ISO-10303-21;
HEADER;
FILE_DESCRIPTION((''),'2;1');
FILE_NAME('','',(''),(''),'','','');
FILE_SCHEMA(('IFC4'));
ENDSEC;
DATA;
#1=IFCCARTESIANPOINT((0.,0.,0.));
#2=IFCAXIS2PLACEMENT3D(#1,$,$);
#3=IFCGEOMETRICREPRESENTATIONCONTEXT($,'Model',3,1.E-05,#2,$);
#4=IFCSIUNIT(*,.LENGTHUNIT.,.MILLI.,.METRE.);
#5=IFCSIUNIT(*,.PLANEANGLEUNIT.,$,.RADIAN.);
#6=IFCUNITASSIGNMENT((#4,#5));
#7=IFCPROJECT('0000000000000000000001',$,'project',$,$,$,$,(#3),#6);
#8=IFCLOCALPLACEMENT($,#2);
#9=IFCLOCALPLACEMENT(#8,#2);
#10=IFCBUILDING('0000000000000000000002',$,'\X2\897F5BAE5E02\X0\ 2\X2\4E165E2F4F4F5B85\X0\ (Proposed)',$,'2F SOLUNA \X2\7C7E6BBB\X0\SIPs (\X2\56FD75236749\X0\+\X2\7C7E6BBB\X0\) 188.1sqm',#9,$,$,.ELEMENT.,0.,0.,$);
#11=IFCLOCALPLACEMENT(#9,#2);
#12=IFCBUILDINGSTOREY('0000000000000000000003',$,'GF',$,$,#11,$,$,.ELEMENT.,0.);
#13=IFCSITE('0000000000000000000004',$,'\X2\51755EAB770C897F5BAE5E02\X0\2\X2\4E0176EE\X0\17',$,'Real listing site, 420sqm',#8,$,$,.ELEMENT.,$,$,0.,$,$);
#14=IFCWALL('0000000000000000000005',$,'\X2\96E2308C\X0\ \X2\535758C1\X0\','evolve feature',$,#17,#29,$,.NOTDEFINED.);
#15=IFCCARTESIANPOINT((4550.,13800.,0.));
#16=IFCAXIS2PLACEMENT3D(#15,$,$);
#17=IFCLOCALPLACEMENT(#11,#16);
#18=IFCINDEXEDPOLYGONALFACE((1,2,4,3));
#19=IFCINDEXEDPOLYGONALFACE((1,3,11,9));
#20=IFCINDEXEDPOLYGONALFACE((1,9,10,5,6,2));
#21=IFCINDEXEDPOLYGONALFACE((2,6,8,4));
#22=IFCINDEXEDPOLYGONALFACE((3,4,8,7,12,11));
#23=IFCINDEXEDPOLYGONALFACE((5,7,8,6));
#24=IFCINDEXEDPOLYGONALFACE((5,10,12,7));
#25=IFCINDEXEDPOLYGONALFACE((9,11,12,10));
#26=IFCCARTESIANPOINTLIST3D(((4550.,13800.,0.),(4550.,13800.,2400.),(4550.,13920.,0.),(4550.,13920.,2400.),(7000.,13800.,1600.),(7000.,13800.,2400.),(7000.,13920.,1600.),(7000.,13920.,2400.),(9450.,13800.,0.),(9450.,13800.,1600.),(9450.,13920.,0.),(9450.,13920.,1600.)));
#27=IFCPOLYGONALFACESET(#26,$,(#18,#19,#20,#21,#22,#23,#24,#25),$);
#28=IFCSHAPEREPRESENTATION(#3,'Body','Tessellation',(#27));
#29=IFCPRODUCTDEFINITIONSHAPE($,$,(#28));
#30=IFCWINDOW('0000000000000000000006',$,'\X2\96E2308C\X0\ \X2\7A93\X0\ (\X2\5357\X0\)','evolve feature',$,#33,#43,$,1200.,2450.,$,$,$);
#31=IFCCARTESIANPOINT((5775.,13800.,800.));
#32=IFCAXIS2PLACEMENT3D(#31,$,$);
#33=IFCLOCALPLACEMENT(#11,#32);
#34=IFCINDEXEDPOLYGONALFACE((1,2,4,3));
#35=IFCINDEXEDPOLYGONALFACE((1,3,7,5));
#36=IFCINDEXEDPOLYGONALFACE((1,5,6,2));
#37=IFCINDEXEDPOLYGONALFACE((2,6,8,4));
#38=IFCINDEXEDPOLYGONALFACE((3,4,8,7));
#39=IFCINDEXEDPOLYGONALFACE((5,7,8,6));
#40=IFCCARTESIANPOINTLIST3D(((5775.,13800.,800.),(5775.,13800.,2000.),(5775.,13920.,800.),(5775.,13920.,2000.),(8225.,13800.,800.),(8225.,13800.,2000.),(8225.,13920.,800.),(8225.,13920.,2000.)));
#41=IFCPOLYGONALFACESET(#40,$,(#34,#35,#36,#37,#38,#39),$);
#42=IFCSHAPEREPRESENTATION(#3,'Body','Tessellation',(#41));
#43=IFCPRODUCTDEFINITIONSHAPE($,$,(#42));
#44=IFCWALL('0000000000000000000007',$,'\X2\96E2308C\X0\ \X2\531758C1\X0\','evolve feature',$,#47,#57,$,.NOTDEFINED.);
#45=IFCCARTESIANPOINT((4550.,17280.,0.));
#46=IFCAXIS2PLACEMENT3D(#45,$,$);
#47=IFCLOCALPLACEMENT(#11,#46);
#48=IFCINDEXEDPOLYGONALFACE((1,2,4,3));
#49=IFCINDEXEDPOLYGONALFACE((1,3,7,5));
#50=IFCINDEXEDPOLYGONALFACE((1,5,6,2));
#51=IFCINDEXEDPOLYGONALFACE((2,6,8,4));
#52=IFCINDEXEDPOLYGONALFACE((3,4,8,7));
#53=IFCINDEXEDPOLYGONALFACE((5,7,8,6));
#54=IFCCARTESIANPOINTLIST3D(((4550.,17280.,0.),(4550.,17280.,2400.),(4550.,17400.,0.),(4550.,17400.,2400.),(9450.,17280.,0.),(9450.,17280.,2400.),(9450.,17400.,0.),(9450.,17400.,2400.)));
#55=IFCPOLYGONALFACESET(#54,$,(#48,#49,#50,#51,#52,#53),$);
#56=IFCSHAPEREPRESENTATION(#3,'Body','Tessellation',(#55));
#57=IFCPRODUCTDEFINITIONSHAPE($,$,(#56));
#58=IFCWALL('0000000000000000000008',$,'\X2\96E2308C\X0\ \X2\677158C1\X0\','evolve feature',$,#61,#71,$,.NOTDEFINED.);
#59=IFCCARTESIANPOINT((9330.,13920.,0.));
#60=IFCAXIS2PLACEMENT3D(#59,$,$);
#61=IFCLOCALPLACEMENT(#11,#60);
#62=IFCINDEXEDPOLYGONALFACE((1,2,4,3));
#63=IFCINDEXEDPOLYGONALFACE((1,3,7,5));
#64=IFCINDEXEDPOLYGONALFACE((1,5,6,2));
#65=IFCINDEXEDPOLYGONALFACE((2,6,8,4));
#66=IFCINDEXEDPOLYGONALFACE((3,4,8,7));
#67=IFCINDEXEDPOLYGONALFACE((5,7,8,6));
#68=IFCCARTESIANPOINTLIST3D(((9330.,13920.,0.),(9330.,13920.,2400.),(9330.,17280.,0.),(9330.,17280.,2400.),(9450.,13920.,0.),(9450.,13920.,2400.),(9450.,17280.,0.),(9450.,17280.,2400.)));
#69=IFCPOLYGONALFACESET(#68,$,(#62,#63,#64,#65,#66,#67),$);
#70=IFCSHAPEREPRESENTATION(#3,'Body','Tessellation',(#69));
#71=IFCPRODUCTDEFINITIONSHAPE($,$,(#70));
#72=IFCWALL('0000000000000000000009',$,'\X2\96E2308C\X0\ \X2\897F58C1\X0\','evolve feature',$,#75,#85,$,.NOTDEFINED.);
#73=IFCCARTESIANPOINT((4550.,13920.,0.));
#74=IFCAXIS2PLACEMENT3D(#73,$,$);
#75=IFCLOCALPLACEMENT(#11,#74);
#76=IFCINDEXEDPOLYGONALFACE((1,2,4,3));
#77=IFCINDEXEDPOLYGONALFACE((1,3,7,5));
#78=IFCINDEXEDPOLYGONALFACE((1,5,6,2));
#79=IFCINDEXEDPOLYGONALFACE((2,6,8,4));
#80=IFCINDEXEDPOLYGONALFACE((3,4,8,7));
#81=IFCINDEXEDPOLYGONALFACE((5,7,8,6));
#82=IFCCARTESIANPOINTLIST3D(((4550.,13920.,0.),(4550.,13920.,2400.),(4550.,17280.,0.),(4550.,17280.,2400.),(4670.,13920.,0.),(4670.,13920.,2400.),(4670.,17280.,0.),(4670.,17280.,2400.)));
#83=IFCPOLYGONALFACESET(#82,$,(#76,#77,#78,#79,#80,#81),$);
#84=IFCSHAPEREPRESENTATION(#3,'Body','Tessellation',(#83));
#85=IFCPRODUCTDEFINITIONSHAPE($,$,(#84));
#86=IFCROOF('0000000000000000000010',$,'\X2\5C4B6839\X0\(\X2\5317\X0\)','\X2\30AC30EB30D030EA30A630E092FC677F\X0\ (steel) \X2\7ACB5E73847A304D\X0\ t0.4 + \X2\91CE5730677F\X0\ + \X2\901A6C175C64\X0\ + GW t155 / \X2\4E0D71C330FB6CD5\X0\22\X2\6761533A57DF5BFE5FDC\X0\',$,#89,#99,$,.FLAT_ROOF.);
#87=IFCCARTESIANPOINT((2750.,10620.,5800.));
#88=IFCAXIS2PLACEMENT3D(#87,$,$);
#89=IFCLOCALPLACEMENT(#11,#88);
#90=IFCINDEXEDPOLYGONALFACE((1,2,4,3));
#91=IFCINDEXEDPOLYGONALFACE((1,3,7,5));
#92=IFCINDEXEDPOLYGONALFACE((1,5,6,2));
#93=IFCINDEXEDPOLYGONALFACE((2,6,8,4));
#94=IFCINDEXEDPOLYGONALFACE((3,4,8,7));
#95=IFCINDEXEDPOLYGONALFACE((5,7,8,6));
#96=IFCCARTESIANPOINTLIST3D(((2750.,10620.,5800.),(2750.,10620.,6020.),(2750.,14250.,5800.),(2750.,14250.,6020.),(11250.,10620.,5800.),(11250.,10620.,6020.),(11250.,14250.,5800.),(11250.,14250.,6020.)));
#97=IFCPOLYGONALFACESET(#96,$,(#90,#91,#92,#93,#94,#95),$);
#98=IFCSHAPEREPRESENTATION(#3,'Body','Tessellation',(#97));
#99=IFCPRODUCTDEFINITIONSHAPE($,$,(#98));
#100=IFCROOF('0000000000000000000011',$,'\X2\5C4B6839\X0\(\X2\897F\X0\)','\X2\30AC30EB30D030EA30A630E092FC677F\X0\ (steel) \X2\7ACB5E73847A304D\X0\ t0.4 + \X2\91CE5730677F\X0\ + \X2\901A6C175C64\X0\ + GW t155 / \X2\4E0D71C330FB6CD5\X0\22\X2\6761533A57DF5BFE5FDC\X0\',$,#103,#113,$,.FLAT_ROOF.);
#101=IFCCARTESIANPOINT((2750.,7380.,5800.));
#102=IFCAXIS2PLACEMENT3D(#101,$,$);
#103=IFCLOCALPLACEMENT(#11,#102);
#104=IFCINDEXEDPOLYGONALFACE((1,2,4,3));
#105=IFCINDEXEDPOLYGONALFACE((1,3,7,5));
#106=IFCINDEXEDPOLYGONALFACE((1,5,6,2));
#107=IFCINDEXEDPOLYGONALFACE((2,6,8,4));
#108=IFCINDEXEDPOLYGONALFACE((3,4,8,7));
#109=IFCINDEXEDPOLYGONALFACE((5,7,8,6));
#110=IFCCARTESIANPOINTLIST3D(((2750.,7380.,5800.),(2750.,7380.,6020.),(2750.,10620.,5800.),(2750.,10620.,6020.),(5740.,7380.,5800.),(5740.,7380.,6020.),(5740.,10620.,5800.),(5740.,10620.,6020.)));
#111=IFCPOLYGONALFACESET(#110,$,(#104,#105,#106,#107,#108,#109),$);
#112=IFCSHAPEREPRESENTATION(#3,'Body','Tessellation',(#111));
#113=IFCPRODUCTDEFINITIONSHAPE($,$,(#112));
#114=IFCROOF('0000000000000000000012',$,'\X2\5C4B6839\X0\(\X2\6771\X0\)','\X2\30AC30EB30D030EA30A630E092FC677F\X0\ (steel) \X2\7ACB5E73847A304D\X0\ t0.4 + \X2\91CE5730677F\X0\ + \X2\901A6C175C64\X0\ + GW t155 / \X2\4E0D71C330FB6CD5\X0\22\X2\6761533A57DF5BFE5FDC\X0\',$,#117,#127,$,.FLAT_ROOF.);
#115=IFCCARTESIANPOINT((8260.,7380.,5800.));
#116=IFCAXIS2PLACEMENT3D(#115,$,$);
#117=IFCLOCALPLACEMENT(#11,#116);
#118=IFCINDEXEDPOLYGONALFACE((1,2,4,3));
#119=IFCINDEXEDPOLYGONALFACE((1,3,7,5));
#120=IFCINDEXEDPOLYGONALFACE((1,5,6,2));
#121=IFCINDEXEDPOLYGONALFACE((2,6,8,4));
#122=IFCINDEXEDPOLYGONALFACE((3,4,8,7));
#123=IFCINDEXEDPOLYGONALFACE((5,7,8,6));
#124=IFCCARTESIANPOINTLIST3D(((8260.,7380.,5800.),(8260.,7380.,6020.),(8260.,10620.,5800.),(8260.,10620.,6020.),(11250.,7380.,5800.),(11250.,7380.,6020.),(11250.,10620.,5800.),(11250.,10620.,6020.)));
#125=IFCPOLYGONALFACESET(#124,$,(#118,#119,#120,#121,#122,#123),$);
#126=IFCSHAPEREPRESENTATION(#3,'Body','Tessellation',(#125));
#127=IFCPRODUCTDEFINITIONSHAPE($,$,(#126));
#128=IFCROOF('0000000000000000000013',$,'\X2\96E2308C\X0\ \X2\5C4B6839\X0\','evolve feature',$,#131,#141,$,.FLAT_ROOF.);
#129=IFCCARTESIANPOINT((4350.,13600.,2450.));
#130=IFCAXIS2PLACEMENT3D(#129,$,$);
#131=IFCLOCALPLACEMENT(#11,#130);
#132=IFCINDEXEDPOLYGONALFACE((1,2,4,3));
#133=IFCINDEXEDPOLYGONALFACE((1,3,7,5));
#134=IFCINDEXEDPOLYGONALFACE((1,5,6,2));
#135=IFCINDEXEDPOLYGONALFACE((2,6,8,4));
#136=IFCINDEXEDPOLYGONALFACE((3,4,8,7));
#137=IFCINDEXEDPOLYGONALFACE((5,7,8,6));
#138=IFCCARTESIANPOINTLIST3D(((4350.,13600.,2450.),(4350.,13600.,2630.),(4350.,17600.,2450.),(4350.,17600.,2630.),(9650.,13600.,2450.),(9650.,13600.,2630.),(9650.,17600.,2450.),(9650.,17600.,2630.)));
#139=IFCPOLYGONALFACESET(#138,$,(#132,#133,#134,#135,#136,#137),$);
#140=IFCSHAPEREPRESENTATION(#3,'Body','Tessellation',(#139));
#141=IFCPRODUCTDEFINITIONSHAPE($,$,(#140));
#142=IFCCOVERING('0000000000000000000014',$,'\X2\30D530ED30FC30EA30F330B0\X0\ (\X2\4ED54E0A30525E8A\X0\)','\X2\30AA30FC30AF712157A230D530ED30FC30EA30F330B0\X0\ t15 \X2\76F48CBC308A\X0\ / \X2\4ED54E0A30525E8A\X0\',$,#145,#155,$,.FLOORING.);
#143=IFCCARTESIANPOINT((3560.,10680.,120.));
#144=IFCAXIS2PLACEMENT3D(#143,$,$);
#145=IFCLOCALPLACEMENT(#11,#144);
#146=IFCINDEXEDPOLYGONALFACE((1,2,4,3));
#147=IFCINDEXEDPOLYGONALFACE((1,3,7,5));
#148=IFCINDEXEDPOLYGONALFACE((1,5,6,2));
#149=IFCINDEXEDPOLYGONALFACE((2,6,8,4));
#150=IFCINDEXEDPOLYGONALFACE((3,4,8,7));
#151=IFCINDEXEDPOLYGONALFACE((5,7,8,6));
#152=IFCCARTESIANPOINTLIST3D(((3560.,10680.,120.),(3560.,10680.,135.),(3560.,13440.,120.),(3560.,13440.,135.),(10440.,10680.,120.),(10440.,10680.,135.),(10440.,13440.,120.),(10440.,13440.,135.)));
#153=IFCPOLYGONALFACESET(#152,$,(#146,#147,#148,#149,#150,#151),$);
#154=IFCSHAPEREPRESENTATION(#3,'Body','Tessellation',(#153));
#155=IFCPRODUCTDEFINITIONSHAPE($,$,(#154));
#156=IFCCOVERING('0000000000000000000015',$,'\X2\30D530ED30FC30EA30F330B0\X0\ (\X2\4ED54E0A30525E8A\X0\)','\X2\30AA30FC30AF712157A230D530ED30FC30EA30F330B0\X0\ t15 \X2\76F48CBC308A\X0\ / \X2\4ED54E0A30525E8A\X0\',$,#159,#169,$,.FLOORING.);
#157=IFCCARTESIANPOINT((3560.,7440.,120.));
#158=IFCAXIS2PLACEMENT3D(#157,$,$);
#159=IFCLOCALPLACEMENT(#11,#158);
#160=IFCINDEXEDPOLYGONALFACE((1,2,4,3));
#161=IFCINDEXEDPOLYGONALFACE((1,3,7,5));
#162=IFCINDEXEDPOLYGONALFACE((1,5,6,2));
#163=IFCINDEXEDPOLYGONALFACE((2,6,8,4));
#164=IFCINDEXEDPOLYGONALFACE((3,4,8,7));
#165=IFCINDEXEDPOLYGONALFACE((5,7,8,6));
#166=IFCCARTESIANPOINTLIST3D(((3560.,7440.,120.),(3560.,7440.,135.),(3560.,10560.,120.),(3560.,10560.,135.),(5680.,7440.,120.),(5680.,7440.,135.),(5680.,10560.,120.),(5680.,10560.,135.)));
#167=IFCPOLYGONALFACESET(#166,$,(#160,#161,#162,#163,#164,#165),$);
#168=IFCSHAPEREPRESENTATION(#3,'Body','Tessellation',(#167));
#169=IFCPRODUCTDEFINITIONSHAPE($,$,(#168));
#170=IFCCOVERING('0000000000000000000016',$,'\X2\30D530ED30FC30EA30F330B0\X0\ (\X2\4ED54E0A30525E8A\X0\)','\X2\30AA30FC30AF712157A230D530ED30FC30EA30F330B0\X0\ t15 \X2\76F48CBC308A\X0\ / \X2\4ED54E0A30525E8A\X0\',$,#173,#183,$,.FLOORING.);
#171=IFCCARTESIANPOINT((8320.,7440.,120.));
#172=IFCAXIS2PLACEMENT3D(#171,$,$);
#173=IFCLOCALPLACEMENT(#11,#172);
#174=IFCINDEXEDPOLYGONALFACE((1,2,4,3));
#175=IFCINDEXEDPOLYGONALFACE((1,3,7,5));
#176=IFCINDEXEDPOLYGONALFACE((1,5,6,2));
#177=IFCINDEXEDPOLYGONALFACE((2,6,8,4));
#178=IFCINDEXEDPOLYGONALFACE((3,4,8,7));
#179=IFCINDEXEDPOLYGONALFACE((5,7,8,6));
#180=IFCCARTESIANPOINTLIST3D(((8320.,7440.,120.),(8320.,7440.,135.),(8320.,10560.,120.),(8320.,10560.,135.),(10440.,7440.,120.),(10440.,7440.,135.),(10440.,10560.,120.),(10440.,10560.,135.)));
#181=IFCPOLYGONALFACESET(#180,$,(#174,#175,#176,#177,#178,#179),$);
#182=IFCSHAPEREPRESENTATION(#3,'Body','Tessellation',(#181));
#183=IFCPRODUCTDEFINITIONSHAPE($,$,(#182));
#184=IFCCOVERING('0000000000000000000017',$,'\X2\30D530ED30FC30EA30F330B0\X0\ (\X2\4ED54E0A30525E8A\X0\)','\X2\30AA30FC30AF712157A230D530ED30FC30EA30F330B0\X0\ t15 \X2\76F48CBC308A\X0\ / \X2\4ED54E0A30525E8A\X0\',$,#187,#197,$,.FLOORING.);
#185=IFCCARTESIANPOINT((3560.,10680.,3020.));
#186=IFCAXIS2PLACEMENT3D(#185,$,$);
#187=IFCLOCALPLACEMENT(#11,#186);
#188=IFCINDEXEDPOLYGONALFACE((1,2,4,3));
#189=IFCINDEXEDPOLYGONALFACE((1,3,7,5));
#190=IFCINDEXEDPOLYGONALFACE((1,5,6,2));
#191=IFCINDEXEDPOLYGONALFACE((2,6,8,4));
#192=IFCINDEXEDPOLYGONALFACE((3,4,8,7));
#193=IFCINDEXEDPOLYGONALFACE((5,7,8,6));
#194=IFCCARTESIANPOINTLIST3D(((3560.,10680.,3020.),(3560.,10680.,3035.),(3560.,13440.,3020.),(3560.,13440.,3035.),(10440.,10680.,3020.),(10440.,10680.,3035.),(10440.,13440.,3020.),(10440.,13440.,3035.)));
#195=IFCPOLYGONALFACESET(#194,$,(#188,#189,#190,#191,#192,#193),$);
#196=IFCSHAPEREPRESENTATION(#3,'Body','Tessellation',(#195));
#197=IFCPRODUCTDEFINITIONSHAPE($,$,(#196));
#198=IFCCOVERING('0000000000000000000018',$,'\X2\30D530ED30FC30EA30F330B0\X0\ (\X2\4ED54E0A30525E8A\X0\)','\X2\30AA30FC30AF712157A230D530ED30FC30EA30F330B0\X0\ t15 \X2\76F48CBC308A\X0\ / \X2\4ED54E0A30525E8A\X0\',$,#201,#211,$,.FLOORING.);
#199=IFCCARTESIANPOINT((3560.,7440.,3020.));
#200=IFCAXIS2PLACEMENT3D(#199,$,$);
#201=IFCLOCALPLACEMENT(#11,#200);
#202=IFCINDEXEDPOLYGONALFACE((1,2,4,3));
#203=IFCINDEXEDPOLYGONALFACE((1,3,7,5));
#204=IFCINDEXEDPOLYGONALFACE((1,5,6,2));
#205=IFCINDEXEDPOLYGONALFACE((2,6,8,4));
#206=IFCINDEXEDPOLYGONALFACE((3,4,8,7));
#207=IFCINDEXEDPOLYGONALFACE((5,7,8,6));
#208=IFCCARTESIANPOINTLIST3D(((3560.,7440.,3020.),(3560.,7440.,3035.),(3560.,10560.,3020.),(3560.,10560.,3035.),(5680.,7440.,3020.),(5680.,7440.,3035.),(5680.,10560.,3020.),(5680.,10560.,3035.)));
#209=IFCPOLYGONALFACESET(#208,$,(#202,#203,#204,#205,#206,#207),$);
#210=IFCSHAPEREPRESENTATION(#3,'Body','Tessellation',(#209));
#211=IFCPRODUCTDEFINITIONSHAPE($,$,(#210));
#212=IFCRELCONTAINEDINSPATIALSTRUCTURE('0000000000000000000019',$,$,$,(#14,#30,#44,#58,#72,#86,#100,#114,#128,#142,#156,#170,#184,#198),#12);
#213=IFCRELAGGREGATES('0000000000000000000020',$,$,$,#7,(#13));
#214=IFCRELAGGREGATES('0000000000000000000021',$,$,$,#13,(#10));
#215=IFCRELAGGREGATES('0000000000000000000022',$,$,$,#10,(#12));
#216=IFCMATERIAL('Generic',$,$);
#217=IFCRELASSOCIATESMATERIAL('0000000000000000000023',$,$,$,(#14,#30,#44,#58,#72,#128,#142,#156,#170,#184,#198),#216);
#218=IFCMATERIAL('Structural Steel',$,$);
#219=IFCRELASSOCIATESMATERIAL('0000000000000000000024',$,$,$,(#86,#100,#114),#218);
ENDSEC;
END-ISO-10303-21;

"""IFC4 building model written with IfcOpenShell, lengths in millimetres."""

from ifc_helpers import new_model, si_unit, frame, frame_2d, origin, place, context, project, spatial, rectangle, extrude, material, element, fill, save


model = new_model("IFC4")

# Units and contexts
model_context = context("Model", 3, precision=1e-05, world=origin())
ifc_project = project(units=[si_unit("LENGTHUNIT", "METRE", prefix="MILLI"), si_unit("PLANEANGLEUNIT", "RADIAN")], contexts=[model_context])

# Site, building, storey
site_placement = place(None, origin())
site = spatial("IfcSite", under=ifc_project, at=site_placement, Name="兵庫県西宮市2丁目17", ObjectType="Real listing site, 420sqm", CompositionType="ELEMENT", RefElevation=0.0)
building_placement = place(site_placement, origin())
building = spatial("IfcBuilding", under=site, at=building_placement, Name="西宮市 2世帯住宅 (Proposed)", ObjectType="2F SOLUNA 籾殻SIPs (国産杉+籾殻) 188.1sqm", CompositionType="ELEMENT", ElevationOfRefHeight=0.0, ElevationOfTerrain=0.0)
storey_placement = place(building_placement, origin())
storey = spatial("IfcBuildingStorey", under=building, at=storey_placement, Name="GF", CompositionType="ELEMENT", Elevation=0.0)

# Shared definitions
ifc_material_1 = material(Name="Generic")

# Wall, opening, window
wall_1_placement = place(storey_placement, frame((4550.0, 13800.0, 0.0)))
wall_1 = element("IfcWall", 1, at=wall_1_placement, inside=storey, material=ifc_material_1, Name="離れ 南壁", Description="evolve feature", PredefinedType="NOTDEFINED", context=model_context, shape_type="SweptSolid", body=[
    extrude(rectangle(XDim=4900.0, YDim=120.0, at=frame_2d((2450.0, 60.0))), frame((4550.0, 13800.0, 0.0)), (0.0, 0.0, 1.0), 2400.0),
])
opening_1_placement = place(storey_placement, frame((5775.0, 13800.0, 800.0)))
opening_1 = element("IfcOpeningElement", 2, at=opening_1_placement, cuts=wall_1, PredefinedType="NOTDEFINED", context=model_context, shape_type="SweptSolid", body=[
    extrude(rectangle(XDim=2450.0, YDim=120.0, at=frame_2d((1225.0, 60.0))), frame((5775.0, 13800.0, 800.0)), (0.0, 0.0, 1.0), 1200.0),
])
window_1_placement = place(storey_placement, frame((5775.0, 13800.0, 800.0)))
window_1 = element("IfcWindow", 3, at=window_1_placement, inside=storey, material=ifc_material_1, Name="離れ 窓 (南)", Description="evolve feature", OverallHeight=1200.0, OverallWidth=2450.0, context=model_context, shape_type="SweptSolid", body=[
    extrude(rectangle(XDim=2450.0, YDim=120.0, at=frame_2d((1225.0, 60.0))), frame((5775.0, 13800.0, 800.0)), (0.0, 0.0, 1.0), 1200.0),
])
fill(opening_1, window_1)

# Walls
wall_2_placement = place(storey_placement, frame((4550.0, 17280.0, 0.0)))
element("IfcWall", 4, at=wall_2_placement, inside=storey, material=ifc_material_1, Name="離れ 北壁", Description="evolve feature", PredefinedType="NOTDEFINED", context=model_context, shape_type="SweptSolid", body=[
    extrude(rectangle(XDim=4900.0, YDim=120.0, at=frame_2d((2450.0, 60.0))), frame((4550.0, 17280.0, 0.0)), (0.0, 0.0, 1.0), 2400.0),
])
wall_3_placement = place(storey_placement, frame((9330.0, 13920.0, 0.0)))
element("IfcWall", 5, at=wall_3_placement, inside=storey, material=ifc_material_1, Name="離れ 東壁", Description="evolve feature", PredefinedType="NOTDEFINED", context=model_context, shape_type="SweptSolid", body=[
    extrude(rectangle(XDim=120.0, YDim=3360.0, at=frame_2d((60.0, 1680.0))), frame((9330.0, 13920.0, 0.0)), (0.0, 0.0, 1.0), 2400.0),
])
wall_4_placement = place(storey_placement, frame((4550.0, 13920.0, 0.0)))
element("IfcWall", 6, at=wall_4_placement, inside=storey, material=ifc_material_1, Name="離れ 西壁", Description="evolve feature", PredefinedType="NOTDEFINED", context=model_context, shape_type="SweptSolid", body=[
    extrude(rectangle(XDim=120.0, YDim=3360.0, at=frame_2d((60.0, 1680.0))), frame((4550.0, 13920.0, 0.0)), (0.0, 0.0, 1.0), 2400.0),
])

# Roofs
ifc_material_2 = material(Name="Structural Steel")
for number, where, name in (
    (7, (2750.0, 10620.0, 5800.0), "屋根(北)"),
):
    element("IfcRoof", number, at=place(storey_placement, frame(where)), inside=storey, material=ifc_material_2, Name=name, Description="ガルバリウム鋼板 (steel) 立平葺き t0.4 + 野地板 + 通気層 + GW t155 / 不燃・法22条区域対応", PredefinedType="FLAT_ROOF", context=model_context, shape_type="SweptSolid", body=[
        extrude(rectangle(XDim=8500.0, YDim=3630.0, at=frame_2d((4250.0, 1815.0))), frame((2750.0, 10620.0, 5800.0)), (0.0, 0.0, 1.0), 220.0),
    ])
roof_1_placement = place(storey_placement, frame((2750.0, 7380.0, 5800.0)))
element("IfcRoof", 8, at=roof_1_placement, inside=storey, material=ifc_material_2, Name="屋根(西)", Description="ガルバリウム鋼板 (steel) 立平葺き t0.4 + 野地板 + 通気層 + GW t155 / 不燃・法22条区域対応", PredefinedType="FLAT_ROOF", context=model_context, shape_type="SweptSolid", body=[
    extrude(rectangle(XDim=2990.0, YDim=3240.0, at=frame_2d((1495.0, 1620.0))), frame((2750.0, 7380.0, 5800.0)), (0.0, 0.0, 1.0), 220.0),
])
roof_2_placement = place(storey_placement, frame((8260.0, 7380.0, 5800.0)))
element("IfcRoof", 9, at=roof_2_placement, inside=storey, material=ifc_material_2, Name="屋根(東)", Description="ガルバリウム鋼板 (steel) 立平葺き t0.4 + 野地板 + 通気層 + GW t155 / 不燃・法22条区域対応", PredefinedType="FLAT_ROOF", context=model_context, shape_type="SweptSolid", body=[
    extrude(rectangle(XDim=2990.0, YDim=3240.0, at=frame_2d((1495.0, 1620.0))), frame((8260.0, 7380.0, 5800.0)), (0.0, 0.0, 1.0), 220.0),
])
roof_3_placement = place(storey_placement, frame((4350.0, 13600.0, 2450.0)))
element("IfcRoof", 10, at=roof_3_placement, inside=storey, material=ifc_material_1, Name="離れ 屋根", Description="evolve feature", PredefinedType="FLAT_ROOF", context=model_context, shape_type="SweptSolid", body=[
    extrude(rectangle(XDim=5300.0, YDim=4000.0, at=frame_2d((2650.0, 2000.0))), frame((4350.0, 13600.0, 2450.0)), (0.0, 0.0, 1.0), 180.0),
])

# Coverings
covering_1_placement = place(storey_placement, frame((3560.0, 10680.0, 120.0)))
element("IfcCovering", 11, at=covering_1_placement, inside=storey, material=ifc_material_1, Name="フローリング (仕上げ床)", Description="オーク無垢フローリング t15 直貼り / 仕上げ床", PredefinedType="FLOORING", context=model_context, shape_type="SweptSolid", body=[
    extrude(rectangle(XDim=6880.0, YDim=2760.0, at=frame_2d((3440.0, 1380.0))), frame((3560.0, 10680.0, 120.0)), (0.0, 0.0, 1.0), 15.0),
])
covering_2_placement = place(storey_placement, frame((3560.0, 7440.0, 120.0)))
element("IfcCovering", 12, at=covering_2_placement, inside=storey, material=ifc_material_1, Name="フローリング (仕上げ床)", Description="オーク無垢フローリング t15 直貼り / 仕上げ床", PredefinedType="FLOORING", context=model_context, shape_type="SweptSolid", body=[
    extrude(rectangle(XDim=2120.0, YDim=3120.0, at=frame_2d((1060.0, 1560.0))), frame((3560.0, 7440.0, 120.0)), (0.0, 0.0, 1.0), 15.0),
])
covering_3_placement = place(storey_placement, frame((8320.0, 7440.0, 120.0)))
element("IfcCovering", 13, at=covering_3_placement, inside=storey, material=ifc_material_1, Name="フローリング (仕上げ床)", Description="オーク無垢フローリング t15 直貼り / 仕上げ床", PredefinedType="FLOORING", context=model_context, shape_type="SweptSolid", body=[
    extrude(rectangle(XDim=2120.0, YDim=3120.0, at=frame_2d((1060.0, 1560.0))), frame((8320.0, 7440.0, 120.0)), (0.0, 0.0, 1.0), 15.0),
])
covering_4_placement = place(storey_placement, frame((3560.0, 10680.0, 3020.0)))
element("IfcCovering", 14, at=covering_4_placement, inside=storey, material=ifc_material_1, Name="フローリング (仕上げ床)", Description="オーク無垢フローリング t15 直貼り / 仕上げ床", PredefinedType="FLOORING", context=model_context, shape_type="SweptSolid", body=[
    extrude(rectangle(XDim=6880.0, YDim=2760.0, at=frame_2d((3440.0, 1380.0))), frame((3560.0, 10680.0, 3020.0)), (0.0, 0.0, 1.0), 15.0),
])
covering_5_placement = place(storey_placement, frame((3560.0, 7440.0, 3020.0)))
element("IfcCovering", 15, at=covering_5_placement, inside=storey, material=ifc_material_1, Name="フローリング (仕上げ床)", Description="オーク無垢フローリング t15 直貼り / 仕上げ床", PredefinedType="FLOORING", context=model_context, shape_type="SweptSolid", body=[
    extrude(rectangle(XDim=2120.0, YDim=3120.0, at=frame_2d((1060.0, 1560.0))), frame((3560.0, 7440.0, 3020.0)), (0.0, 0.0, 1.0), 15.0),
])

save(model, "model.ifc")
